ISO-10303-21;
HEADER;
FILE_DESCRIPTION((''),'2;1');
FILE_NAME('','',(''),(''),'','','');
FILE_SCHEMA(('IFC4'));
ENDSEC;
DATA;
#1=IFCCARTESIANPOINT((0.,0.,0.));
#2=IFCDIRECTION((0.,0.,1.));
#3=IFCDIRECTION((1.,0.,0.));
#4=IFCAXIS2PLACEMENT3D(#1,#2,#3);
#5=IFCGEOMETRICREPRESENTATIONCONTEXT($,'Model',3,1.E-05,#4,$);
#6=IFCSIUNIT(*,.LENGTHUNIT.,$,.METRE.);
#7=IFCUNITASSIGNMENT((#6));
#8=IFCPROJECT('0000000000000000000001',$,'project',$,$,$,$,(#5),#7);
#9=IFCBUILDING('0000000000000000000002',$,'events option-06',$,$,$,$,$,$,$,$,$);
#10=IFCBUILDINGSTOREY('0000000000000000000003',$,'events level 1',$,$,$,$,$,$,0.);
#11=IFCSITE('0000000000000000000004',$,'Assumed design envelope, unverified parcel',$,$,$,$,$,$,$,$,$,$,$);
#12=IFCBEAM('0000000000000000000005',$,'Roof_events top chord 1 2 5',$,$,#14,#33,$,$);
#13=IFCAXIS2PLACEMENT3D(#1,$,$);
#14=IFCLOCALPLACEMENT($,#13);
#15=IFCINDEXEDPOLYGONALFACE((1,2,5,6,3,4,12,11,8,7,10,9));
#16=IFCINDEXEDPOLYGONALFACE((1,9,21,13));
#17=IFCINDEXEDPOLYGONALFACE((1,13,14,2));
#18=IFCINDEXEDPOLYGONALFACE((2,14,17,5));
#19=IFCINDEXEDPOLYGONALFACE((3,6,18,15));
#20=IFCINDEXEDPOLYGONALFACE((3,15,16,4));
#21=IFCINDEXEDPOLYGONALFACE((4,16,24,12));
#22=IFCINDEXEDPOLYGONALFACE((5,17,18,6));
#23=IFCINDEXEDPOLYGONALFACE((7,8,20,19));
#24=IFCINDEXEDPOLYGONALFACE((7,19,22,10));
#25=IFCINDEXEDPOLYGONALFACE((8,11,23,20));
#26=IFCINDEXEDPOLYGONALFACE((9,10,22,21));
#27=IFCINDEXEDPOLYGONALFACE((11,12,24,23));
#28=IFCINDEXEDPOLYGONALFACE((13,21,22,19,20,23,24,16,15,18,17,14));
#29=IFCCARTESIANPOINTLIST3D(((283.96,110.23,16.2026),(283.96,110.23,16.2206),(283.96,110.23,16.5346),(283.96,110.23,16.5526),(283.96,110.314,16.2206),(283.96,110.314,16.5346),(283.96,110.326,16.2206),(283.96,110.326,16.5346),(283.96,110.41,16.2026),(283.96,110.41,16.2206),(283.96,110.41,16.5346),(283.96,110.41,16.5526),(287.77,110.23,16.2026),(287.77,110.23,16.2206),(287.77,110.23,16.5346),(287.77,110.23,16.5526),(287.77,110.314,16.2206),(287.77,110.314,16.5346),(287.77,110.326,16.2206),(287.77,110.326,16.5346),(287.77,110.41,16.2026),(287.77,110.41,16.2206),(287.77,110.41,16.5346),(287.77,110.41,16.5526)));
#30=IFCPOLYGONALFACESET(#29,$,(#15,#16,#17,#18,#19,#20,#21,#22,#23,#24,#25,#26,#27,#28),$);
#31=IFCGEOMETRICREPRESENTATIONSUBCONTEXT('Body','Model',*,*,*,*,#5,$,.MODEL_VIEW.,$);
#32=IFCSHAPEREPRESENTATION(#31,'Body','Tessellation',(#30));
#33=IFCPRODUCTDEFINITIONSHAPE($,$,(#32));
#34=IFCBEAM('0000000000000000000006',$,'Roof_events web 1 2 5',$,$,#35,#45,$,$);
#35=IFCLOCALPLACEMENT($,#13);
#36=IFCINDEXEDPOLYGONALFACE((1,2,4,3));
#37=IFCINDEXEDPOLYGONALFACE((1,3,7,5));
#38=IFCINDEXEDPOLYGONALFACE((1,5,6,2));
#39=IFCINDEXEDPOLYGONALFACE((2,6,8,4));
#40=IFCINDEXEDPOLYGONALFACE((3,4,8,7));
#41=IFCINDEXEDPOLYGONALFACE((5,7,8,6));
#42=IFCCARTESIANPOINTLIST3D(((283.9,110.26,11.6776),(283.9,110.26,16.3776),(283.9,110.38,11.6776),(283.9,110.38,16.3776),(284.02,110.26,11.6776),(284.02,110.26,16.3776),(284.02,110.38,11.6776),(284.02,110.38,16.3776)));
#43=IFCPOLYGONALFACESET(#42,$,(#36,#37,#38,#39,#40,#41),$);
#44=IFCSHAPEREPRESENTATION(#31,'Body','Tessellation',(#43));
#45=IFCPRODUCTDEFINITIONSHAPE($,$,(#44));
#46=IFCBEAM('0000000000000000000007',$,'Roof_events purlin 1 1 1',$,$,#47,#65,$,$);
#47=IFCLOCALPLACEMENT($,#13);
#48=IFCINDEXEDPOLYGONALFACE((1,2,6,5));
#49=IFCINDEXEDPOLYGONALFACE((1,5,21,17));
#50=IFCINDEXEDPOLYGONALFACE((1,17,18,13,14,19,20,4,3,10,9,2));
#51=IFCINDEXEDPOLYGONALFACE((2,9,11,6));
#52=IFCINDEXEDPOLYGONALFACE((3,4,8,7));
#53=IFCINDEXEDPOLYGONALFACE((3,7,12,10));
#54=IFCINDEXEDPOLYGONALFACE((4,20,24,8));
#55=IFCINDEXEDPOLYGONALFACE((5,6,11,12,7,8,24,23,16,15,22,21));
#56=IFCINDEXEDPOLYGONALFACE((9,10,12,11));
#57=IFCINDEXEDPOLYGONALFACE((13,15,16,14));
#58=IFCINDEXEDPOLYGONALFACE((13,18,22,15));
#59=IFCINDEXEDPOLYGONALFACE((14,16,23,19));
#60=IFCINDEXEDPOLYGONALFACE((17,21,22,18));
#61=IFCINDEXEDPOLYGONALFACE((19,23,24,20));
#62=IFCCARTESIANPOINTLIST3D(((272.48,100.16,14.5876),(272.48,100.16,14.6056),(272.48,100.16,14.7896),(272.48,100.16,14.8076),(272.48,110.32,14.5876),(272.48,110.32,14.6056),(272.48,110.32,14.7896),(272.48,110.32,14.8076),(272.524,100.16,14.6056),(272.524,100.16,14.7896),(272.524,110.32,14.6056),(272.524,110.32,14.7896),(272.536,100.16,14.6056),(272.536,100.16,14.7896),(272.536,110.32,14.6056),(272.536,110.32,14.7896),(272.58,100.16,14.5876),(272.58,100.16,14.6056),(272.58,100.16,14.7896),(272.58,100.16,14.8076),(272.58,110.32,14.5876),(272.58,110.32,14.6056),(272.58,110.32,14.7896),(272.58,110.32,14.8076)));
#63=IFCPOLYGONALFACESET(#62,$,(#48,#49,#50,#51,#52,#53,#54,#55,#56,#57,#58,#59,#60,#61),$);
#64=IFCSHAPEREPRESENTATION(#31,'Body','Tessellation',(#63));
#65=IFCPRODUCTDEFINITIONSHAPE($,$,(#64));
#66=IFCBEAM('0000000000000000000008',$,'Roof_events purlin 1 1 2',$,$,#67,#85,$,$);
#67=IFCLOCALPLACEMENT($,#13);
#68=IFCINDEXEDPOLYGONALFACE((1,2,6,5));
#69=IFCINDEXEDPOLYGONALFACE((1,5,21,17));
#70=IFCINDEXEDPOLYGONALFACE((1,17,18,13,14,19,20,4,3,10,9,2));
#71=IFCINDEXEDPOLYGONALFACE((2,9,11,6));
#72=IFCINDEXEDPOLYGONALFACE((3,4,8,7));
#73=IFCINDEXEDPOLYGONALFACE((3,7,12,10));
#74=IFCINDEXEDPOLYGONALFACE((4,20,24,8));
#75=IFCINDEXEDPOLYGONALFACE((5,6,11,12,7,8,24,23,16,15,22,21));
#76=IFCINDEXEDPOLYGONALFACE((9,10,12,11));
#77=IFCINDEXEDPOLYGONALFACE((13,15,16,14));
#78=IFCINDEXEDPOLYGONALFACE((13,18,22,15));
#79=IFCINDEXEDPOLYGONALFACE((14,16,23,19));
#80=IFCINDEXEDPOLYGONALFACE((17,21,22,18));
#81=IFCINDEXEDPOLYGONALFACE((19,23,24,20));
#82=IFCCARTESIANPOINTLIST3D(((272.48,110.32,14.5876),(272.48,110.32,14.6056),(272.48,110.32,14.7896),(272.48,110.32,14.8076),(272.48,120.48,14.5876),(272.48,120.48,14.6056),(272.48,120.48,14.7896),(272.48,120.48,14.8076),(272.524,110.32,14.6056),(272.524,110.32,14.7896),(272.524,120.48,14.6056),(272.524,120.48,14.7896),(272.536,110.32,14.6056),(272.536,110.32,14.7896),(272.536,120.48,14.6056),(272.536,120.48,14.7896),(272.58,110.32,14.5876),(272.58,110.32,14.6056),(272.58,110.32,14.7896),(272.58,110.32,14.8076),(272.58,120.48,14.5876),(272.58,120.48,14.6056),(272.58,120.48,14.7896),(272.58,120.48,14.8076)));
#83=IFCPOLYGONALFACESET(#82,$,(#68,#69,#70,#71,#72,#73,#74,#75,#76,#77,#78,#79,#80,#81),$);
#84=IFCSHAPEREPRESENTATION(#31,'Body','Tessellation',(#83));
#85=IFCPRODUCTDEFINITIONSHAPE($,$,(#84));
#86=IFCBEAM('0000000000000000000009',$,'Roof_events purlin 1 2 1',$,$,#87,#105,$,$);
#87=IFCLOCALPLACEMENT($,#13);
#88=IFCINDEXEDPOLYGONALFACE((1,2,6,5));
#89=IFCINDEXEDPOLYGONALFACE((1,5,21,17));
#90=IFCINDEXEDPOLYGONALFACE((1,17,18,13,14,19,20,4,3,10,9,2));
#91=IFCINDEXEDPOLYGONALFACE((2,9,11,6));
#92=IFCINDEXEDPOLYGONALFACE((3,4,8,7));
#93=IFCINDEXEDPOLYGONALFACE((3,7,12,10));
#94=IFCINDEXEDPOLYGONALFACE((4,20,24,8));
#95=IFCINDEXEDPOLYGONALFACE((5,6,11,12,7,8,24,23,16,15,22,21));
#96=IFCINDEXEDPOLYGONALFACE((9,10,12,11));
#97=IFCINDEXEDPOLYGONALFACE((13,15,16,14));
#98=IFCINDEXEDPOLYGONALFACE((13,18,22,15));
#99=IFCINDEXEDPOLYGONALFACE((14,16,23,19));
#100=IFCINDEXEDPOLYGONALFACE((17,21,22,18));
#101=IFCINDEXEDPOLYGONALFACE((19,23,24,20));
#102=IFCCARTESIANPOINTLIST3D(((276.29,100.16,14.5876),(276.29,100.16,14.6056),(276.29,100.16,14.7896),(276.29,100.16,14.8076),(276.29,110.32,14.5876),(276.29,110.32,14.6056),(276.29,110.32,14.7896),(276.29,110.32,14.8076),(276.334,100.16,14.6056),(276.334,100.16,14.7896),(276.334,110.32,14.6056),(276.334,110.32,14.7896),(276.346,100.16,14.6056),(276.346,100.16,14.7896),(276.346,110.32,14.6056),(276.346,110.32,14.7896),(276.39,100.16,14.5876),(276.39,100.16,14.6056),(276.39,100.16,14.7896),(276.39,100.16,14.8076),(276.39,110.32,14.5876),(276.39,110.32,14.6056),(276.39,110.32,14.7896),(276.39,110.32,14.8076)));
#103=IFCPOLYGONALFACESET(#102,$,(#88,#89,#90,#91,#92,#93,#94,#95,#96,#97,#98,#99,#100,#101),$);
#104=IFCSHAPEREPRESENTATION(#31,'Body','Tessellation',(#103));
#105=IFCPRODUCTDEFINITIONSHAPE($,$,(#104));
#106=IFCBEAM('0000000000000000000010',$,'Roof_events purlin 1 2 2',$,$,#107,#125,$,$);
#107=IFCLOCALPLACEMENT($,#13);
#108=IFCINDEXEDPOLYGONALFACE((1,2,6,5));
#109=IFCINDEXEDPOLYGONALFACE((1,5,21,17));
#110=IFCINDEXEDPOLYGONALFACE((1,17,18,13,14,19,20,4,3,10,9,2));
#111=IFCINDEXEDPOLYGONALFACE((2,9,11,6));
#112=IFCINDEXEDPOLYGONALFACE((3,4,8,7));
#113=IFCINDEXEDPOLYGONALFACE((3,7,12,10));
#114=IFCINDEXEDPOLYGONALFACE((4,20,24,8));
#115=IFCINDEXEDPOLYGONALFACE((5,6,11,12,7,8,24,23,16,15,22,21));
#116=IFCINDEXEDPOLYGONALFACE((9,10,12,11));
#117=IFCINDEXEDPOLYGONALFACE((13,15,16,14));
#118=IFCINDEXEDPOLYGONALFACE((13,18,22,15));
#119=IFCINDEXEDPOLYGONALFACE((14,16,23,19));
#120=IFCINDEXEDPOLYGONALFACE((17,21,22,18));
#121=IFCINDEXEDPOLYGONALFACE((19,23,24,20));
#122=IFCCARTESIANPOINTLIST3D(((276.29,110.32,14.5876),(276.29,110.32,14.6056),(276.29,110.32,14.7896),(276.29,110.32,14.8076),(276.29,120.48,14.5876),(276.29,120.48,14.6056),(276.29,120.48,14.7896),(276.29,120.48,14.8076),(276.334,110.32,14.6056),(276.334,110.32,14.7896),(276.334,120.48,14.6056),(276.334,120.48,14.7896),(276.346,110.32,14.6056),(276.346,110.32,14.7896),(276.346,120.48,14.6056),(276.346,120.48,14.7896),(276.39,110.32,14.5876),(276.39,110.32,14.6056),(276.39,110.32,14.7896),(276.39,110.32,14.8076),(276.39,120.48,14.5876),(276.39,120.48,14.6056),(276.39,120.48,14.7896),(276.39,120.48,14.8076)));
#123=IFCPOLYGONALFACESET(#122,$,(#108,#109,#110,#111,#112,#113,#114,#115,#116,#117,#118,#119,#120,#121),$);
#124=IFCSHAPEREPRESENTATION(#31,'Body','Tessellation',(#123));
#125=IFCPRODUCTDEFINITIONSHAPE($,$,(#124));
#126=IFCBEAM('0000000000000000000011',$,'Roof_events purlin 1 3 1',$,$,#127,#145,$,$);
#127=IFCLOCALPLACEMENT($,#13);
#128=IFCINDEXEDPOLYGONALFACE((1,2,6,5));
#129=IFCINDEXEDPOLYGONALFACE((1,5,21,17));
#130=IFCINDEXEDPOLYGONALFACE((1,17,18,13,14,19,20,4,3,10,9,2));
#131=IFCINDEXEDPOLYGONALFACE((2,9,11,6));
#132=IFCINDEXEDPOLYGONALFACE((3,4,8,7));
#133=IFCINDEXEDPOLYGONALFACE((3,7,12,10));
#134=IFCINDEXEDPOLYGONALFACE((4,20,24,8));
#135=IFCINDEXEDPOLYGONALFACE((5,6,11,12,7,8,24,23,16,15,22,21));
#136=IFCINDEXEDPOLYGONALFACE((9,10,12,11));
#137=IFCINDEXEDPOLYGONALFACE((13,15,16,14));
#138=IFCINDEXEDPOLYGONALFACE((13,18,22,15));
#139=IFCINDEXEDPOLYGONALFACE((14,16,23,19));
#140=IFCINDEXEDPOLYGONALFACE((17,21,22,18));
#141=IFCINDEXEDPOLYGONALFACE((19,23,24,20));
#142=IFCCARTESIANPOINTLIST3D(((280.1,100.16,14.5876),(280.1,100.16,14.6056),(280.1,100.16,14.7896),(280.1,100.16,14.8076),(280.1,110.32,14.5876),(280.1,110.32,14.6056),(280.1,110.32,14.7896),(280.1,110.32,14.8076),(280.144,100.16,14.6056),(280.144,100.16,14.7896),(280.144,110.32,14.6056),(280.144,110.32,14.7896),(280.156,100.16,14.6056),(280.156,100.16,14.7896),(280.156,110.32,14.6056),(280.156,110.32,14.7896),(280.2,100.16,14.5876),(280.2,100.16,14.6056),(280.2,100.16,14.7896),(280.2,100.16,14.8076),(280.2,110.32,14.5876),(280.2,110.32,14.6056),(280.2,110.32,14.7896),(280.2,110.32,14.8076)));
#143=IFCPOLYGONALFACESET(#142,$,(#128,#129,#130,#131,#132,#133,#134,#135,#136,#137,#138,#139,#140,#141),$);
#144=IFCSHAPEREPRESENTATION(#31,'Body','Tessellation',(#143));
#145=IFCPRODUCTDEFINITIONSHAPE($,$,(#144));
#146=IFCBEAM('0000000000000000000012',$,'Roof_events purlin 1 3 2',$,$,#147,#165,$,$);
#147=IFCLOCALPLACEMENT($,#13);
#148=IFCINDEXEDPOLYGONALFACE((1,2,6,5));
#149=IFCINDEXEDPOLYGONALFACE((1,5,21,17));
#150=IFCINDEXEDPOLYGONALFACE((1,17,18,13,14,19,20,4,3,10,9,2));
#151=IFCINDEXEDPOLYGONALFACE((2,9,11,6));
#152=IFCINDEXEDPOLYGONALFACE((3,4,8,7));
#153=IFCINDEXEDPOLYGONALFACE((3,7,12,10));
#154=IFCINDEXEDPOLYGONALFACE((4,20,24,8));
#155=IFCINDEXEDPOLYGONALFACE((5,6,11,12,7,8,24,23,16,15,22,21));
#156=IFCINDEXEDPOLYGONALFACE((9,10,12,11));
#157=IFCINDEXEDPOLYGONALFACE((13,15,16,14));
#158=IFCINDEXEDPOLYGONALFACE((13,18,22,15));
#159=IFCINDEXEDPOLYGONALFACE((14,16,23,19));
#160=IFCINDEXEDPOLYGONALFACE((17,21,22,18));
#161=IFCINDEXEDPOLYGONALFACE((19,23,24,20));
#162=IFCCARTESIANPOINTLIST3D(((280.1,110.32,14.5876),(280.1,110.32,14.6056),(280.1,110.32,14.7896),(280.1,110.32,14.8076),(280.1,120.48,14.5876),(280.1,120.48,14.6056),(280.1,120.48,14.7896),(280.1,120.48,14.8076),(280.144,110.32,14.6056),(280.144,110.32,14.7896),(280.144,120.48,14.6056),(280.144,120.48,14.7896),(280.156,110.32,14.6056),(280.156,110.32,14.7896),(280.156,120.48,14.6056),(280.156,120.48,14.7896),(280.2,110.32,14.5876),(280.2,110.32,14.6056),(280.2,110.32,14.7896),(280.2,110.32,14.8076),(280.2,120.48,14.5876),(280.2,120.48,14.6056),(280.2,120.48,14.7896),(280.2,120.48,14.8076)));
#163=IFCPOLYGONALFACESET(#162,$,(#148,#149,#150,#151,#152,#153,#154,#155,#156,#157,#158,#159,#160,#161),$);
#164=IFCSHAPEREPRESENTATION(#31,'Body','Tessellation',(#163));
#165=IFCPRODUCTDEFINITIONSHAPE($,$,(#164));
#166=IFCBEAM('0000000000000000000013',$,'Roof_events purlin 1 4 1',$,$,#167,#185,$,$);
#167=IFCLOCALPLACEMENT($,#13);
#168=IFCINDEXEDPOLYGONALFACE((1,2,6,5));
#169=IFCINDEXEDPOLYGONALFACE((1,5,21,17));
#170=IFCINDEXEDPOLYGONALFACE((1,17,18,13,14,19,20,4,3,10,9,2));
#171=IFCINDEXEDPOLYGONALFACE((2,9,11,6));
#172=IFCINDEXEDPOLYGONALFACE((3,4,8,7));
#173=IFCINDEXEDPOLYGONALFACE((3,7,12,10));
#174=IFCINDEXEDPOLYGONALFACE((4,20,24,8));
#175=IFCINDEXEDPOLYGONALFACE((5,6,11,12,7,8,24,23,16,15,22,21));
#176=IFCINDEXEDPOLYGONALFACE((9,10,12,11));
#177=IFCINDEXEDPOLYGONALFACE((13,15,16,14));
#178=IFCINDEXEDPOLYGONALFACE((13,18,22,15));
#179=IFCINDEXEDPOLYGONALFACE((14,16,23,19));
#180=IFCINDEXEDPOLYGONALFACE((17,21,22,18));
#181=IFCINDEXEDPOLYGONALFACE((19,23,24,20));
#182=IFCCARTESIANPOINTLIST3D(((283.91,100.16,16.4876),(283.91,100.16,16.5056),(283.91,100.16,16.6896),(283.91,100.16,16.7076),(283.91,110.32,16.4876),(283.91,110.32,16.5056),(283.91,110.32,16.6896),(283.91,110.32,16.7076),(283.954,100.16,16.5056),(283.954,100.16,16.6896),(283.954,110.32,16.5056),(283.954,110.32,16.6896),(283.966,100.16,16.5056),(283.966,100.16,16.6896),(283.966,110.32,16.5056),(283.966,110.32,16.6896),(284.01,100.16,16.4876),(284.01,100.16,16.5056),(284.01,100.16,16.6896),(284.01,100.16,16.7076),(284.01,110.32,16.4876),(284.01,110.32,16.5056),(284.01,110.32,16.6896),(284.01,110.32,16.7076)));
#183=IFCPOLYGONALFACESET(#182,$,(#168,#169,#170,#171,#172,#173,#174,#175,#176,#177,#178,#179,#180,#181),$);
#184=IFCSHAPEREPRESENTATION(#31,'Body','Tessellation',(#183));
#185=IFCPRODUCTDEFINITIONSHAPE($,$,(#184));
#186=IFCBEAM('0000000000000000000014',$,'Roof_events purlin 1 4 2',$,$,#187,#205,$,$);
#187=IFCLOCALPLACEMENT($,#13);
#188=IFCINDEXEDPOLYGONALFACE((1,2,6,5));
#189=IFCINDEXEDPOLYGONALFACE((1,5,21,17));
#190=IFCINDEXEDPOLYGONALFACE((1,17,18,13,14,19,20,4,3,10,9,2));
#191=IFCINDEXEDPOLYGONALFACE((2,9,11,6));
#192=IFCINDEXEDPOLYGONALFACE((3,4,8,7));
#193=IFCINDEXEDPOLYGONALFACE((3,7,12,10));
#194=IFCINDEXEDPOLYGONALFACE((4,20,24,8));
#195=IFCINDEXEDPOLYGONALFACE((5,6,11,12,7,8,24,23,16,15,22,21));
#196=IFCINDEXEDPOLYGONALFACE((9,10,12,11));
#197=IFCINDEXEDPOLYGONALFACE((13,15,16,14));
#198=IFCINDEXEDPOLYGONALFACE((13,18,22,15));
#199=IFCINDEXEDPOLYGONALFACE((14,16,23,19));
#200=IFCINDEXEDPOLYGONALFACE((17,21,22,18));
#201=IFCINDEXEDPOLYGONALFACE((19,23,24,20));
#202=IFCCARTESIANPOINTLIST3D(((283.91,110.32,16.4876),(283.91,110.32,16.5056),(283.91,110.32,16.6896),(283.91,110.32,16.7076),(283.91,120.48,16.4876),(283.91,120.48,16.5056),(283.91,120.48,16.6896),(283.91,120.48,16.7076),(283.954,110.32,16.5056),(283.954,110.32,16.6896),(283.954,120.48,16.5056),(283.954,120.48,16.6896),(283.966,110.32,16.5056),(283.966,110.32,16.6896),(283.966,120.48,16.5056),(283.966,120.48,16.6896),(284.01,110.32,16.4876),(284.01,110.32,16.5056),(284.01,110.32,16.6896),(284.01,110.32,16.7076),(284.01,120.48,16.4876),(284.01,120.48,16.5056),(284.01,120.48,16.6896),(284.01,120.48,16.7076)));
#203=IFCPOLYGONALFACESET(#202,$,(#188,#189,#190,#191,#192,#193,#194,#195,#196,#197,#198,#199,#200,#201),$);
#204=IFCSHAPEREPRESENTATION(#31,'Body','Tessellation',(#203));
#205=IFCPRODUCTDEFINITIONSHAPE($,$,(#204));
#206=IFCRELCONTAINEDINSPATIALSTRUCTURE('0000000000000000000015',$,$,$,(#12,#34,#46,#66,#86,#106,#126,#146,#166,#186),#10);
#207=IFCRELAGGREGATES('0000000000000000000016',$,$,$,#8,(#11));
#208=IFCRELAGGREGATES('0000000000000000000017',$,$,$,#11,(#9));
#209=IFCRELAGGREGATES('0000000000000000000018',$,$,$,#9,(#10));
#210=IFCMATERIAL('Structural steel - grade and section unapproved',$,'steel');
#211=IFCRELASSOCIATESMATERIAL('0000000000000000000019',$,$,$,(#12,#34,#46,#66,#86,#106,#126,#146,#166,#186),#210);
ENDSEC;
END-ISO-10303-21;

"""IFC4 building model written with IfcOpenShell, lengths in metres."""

from ifc_helpers import new_model, si_unit, frame, origin_with_axes, place, context, subcontext, project, spatial, rectangle, i_section, extrude, material, element, save


model = new_model("IFC4")

# Units and contexts
model_context = context("Model", 3, precision=1e-05, world=origin_with_axes())
body_context = subcontext(model_context, "Body", "Model", "MODEL_VIEW")
ifc_project = project(units=[si_unit("LENGTHUNIT", "METRE")], contexts=[model_context])

# Site, building, storey
site = spatial("IfcSite", under=ifc_project, Name="Assumed design envelope, unverified parcel")
building = spatial("IfcBuilding", under=site, Name="events option-06")
storey = spatial("IfcBuildingStorey", under=building, Name="events level 1", Elevation=0.0)

# Shared definitions
ifc_material = material(Name="Structural steel - grade and section unapproved", Category="steel")

# Beams
beam_1_placement = place(None, frame((283.96, 110.32, 16.3776), z_axis=(1.0, 0.0, 0.0), x_axis=(0.0, 1.0, 0.0)))
element("IfcBeam", 1, at=beam_1_placement, inside=storey, material=ifc_material, Name="Roof_events top chord 1 2 5", context=body_context, shape_type="SweptSolid", body=[
    extrude(i_section(OverallWidth=0.18, OverallDepth=0.35, WebThickness=0.012, FlangeThickness=0.018, FilletRadius=0.0), origin_with_axes(), (0.0, 0.0, 1.0), 3.81),
])
beam_2_placement = place(None, frame((283.96, 110.32, 11.6776), z_axis=(0.0, 0.0, 1.0), x_axis=(-1.0, 0.0, 0.0)))
element("IfcBeam", 2, at=beam_2_placement, inside=storey, material=ifc_material, Name="Roof_events web 1 2 5", context=body_context, shape_type="SweptSolid", body=[
    extrude(rectangle(XDim=0.12, YDim=0.12), origin_with_axes(), (0.0, 0.0, 1.0), 4.7),
])
beam_3_placement = place(None, frame((272.53, 100.16, 14.6976), z_axis=(0.0, 1.0, 0.0), x_axis=(-1.0, 0.0, 0.0)))
element("IfcBeam", 3, at=beam_3_placement, inside=storey, material=ifc_material, Name="Roof_events purlin 1 1 1", context=body_context, shape_type="SweptSolid", body=[
    extrude(i_section(OverallWidth=0.1, OverallDepth=0.22, WebThickness=0.012, FlangeThickness=0.018, FilletRadius=0.0), origin_with_axes(), (0.0, 0.0, 1.0), 10.16),
])
beam_4_placement = place(None, frame((272.53, 110.32, 14.6976), z_axis=(0.0, 1.0, 0.0), x_axis=(-1.0, 0.0, 0.0)))
element("IfcBeam", 4, at=beam_4_placement, inside=storey, material=ifc_material, Name="Roof_events purlin 1 1 2", context=body_context, shape_type="SweptSolid", body=[
    extrude(i_section(OverallWidth=0.1, OverallDepth=0.22, WebThickness=0.012, FlangeThickness=0.018, FilletRadius=0.0), origin_with_axes(), (0.0, 0.0, 1.0), 10.16),
])
beam_5_placement = place(None, frame((276.34, 100.16, 14.6976), z_axis=(0.0, 1.0, 0.0), x_axis=(-1.0, 0.0, 0.0)))
element("IfcBeam", 5, at=beam_5_placement, inside=storey, material=ifc_material, Name="Roof_events purlin 1 2 1", context=body_context, shape_type="SweptSolid", body=[
    extrude(i_section(OverallWidth=0.1, OverallDepth=0.22, WebThickness=0.012, FlangeThickness=0.018, FilletRadius=0.0), origin_with_axes(), (0.0, 0.0, 1.0), 10.16),
])
beam_6_placement = place(None, frame((276.34, 110.32, 14.6976), z_axis=(0.0, 1.0, 0.0), x_axis=(-1.0, 0.0, 0.0)))
element("IfcBeam", 6, at=beam_6_placement, inside=storey, material=ifc_material, Name="Roof_events purlin 1 2 2", context=body_context, shape_type="SweptSolid", body=[
    extrude(i_section(OverallWidth=0.1, OverallDepth=0.22, WebThickness=0.012, FlangeThickness=0.018, FilletRadius=0.0), origin_with_axes(), (0.0, 0.0, 1.0), 10.16),
])
beam_7_placement = place(None, frame((280.15, 100.16, 14.6976), z_axis=(0.0, 1.0, 0.0), x_axis=(-1.0, 0.0, 0.0)))
element("IfcBeam", 7, at=beam_7_placement, inside=storey, material=ifc_material, Name="Roof_events purlin 1 3 1", context=body_context, shape_type="SweptSolid", body=[
    extrude(i_section(OverallWidth=0.1, OverallDepth=0.22, WebThickness=0.012, FlangeThickness=0.018, FilletRadius=0.0), origin_with_axes(), (0.0, 0.0, 1.0), 10.16),
])
beam_8_placement = place(None, frame((280.15, 110.32, 14.6976), z_axis=(0.0, 1.0, 0.0), x_axis=(-1.0, 0.0, 0.0)))
element("IfcBeam", 8, at=beam_8_placement, inside=storey, material=ifc_material, Name="Roof_events purlin 1 3 2", context=body_context, shape_type="SweptSolid", body=[
    extrude(i_section(OverallWidth=0.1, OverallDepth=0.22, WebThickness=0.012, FlangeThickness=0.018, FilletRadius=0.0), origin_with_axes(), (0.0, 0.0, 1.0), 10.16),
])
beam_9_placement = place(None, frame((283.96, 100.16, 16.5976), z_axis=(0.0, 1.0, 0.0), x_axis=(-1.0, 0.0, 0.0)))
element("IfcBeam", 9, at=beam_9_placement, inside=storey, material=ifc_material, Name="Roof_events purlin 1 4 1", context=body_context, shape_type="SweptSolid", body=[
    extrude(i_section(OverallWidth=0.1, OverallDepth=0.22, WebThickness=0.012, FlangeThickness=0.018, FilletRadius=0.0), origin_with_axes(), (0.0, 0.0, 1.0), 10.16),
])
beam_10_placement = place(None, frame((283.96, 110.32, 16.5976), z_axis=(0.0, 1.0, 0.0), x_axis=(-1.0, 0.0, 0.0)))
element("IfcBeam", 10, at=beam_10_placement, inside=storey, material=ifc_material, Name="Roof_events purlin 1 4 2", context=body_context, shape_type="SweptSolid", body=[
    extrude(i_section(OverallWidth=0.1, OverallDepth=0.22, WebThickness=0.012, FlangeThickness=0.018, FilletRadius=0.0), origin_with_axes(), (0.0, 0.0, 1.0), 10.16),
])

save(model, "model.ifc")
